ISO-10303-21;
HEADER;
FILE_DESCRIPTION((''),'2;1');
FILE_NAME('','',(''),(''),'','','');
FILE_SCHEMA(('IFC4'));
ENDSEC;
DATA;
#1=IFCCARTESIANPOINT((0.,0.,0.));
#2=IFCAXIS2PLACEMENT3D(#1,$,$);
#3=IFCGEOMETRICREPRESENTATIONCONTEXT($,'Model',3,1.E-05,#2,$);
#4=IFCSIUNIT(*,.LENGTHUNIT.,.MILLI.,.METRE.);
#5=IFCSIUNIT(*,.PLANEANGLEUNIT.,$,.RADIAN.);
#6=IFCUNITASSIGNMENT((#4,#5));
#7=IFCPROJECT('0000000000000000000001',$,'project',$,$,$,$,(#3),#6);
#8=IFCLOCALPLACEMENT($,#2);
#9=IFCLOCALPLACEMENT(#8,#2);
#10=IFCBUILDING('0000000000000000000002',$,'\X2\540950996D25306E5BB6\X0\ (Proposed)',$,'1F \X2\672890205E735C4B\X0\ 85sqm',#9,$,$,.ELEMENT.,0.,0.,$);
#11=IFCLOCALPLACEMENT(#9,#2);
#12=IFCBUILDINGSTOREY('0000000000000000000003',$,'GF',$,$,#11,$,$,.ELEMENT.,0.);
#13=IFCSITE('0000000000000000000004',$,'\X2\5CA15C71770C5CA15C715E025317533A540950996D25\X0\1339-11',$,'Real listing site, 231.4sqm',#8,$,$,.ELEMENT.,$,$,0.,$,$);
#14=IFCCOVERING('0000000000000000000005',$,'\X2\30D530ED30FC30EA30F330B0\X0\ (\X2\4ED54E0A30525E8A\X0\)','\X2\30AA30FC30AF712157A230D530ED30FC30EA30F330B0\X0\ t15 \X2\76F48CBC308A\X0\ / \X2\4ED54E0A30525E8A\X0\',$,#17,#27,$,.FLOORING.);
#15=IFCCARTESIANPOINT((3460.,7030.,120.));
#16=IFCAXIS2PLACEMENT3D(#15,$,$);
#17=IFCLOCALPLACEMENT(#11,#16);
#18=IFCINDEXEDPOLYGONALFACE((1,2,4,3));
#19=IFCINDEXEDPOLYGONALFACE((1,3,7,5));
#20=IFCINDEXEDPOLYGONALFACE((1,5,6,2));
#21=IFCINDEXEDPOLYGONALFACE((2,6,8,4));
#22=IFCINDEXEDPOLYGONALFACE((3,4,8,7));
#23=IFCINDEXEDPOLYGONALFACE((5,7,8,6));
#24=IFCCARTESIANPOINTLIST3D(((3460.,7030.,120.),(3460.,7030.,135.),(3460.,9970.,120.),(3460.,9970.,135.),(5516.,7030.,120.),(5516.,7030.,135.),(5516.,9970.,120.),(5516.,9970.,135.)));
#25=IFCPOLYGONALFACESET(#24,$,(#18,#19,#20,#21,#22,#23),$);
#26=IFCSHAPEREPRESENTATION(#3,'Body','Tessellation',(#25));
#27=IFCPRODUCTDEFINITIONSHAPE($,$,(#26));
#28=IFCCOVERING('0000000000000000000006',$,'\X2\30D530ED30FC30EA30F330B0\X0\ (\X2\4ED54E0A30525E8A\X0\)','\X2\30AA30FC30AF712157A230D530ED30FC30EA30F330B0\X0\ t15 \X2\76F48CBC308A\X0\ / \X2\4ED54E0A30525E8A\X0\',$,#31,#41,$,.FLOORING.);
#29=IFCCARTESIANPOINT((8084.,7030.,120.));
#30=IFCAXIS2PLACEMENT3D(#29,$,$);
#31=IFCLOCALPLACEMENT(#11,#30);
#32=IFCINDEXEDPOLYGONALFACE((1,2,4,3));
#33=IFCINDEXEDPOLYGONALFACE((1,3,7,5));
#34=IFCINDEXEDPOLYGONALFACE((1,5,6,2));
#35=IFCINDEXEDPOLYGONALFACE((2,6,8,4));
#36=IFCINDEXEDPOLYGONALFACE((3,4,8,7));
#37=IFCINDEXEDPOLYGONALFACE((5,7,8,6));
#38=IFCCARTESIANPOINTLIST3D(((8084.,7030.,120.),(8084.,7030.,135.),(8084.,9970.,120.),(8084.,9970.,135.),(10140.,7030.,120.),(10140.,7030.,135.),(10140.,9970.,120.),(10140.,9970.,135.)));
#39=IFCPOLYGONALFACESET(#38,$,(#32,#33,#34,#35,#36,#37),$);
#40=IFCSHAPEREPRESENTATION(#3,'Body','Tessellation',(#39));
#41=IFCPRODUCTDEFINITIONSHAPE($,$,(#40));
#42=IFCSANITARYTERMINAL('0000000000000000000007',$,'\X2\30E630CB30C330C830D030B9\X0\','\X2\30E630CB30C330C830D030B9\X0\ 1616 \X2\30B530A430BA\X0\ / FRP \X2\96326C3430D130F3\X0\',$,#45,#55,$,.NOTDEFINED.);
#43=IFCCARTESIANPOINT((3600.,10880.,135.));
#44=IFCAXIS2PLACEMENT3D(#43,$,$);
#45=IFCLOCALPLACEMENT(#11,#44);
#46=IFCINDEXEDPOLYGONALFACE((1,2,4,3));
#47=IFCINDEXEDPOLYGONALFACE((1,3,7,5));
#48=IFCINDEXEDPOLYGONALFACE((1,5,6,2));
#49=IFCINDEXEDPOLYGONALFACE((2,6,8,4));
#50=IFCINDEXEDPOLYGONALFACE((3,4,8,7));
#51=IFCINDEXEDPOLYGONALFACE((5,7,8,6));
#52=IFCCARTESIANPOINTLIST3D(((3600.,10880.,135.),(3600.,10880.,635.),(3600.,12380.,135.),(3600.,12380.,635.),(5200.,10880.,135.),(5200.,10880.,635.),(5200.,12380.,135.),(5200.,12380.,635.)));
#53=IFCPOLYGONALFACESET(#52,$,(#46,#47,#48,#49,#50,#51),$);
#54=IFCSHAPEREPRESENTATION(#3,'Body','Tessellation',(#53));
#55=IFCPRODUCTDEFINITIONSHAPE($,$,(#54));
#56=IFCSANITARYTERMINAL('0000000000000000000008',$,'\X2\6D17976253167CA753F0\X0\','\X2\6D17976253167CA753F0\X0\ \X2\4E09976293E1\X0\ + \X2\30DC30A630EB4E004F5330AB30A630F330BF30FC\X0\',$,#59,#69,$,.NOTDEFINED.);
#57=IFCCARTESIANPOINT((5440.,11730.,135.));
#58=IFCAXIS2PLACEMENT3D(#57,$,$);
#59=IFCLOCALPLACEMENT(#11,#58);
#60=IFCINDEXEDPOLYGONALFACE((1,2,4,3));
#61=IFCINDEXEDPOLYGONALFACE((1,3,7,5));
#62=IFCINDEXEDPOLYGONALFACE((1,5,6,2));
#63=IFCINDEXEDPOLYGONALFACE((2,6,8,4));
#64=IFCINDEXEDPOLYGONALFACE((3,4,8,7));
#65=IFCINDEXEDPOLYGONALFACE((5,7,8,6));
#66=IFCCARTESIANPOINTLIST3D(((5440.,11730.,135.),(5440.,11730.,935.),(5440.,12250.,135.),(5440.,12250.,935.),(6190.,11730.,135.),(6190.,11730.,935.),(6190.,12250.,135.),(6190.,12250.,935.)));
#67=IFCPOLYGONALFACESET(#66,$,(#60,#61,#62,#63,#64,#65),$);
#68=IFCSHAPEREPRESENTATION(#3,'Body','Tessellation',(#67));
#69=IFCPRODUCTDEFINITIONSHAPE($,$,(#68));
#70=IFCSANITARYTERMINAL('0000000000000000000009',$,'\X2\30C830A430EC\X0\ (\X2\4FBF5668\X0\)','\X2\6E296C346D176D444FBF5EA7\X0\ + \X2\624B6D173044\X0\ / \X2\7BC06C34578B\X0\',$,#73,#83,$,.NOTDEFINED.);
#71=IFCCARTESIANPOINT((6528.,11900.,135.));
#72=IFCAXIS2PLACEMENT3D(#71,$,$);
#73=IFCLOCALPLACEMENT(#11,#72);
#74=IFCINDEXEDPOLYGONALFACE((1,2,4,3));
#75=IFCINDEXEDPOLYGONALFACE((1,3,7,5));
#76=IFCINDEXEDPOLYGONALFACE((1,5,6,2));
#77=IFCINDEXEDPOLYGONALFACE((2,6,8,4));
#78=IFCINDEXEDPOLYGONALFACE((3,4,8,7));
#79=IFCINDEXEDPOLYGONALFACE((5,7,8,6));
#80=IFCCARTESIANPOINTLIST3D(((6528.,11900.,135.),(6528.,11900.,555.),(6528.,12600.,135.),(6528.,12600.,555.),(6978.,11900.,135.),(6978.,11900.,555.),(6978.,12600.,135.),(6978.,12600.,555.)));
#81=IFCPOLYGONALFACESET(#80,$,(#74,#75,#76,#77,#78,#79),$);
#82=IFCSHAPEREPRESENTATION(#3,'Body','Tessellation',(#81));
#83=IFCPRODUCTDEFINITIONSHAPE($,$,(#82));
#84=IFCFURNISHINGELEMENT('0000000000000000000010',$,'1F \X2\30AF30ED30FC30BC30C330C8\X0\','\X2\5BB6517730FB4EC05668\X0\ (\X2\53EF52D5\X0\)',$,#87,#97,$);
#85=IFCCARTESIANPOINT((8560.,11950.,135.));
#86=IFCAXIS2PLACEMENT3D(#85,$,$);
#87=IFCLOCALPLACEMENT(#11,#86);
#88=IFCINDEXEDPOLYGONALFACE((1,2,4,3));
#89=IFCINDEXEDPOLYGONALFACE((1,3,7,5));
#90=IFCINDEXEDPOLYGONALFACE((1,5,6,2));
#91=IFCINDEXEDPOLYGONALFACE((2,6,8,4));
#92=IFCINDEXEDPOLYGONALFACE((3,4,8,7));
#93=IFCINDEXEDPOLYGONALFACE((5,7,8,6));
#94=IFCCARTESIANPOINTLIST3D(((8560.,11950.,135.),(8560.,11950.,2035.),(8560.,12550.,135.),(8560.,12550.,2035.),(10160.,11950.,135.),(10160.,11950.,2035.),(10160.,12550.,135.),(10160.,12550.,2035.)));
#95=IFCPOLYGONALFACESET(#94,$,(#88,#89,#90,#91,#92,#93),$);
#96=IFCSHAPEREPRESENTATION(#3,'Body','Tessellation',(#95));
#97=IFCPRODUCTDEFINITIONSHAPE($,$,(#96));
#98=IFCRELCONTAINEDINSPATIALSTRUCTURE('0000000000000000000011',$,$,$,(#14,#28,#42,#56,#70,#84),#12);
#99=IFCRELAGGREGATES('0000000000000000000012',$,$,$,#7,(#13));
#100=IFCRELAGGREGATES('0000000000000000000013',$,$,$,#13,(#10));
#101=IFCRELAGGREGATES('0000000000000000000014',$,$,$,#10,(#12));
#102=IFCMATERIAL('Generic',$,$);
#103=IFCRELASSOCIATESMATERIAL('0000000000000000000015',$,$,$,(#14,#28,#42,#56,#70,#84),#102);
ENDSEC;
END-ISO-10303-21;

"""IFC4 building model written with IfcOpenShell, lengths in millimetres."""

from ifc_helpers import new_model, si_unit, frame, frame_2d, origin, place, context, project, spatial, rectangle, extrude, material, element, save


model = new_model("IFC4")

# Units and contexts
model_context = context("Model", 3, precision=1e-05, world=origin())
ifc_project = project(units=[si_unit("LENGTHUNIT", "METRE", prefix="MILLI"), si_unit("PLANEANGLEUNIT", "RADIAN")], contexts=[model_context])

# Site, building, storey
site_placement = place(None, origin())
site = spatial("IfcSite", under=ifc_project, at=site_placement, Name="岡山県岡山市北区吉備津1339-11", ObjectType="Real listing site, 231.4sqm", CompositionType="ELEMENT", RefElevation=0.0)
building_placement = place(site_placement, origin())
building = spatial("IfcBuilding", under=site, at=building_placement, Name="吉備津の家 (Proposed)", ObjectType="1F 木造平屋 85sqm", CompositionType="ELEMENT", ElevationOfRefHeight=0.0, ElevationOfTerrain=0.0)
storey_placement = place(building_placement, origin())
storey = spatial("IfcBuildingStorey", under=building, at=storey_placement, Name="GF", CompositionType="ELEMENT", Elevation=0.0)

# Coverings
ifc_material_1 = material(Name="Generic")
covering_1_placement = place(storey_placement, frame((3460.0, 7030.0, 120.0)))
element("IfcCovering", 1, at=covering_1_placement, inside=storey, material=ifc_material_1, Name="フローリング (仕上げ床)", Description="オーク無垢フローリング t15 直貼り / 仕上げ床", PredefinedType="FLOORING", context=model_context, shape_type="SweptSolid", body=[
    extrude(rectangle(XDim=2056.0, YDim=2940.0, at=frame_2d((1028.0, 1470.0))), frame((3460.0, 7030.0, 120.0)), (0.0, 0.0, 1.0), 15.0),
])
covering_2_placement = place(storey_placement, frame((8084.0, 7030.0, 120.0)))
element("IfcCovering", 2, at=covering_2_placement, inside=storey, material=ifc_material_1, Name="フローリング (仕上げ床)", Description="オーク無垢フローリング t15 直貼り / 仕上げ床", PredefinedType="FLOORING", context=model_context, shape_type="SweptSolid", body=[
    extrude(rectangle(XDim=2056.0, YDim=2940.0, at=frame_2d((1028.0, 1470.0))), frame((8084.0, 7030.0, 120.0)), (0.0, 0.0, 1.0), 15.0),
])

# Sanitary terminals
sanitary_terminal_1_placement = place(storey_placement, frame((3600.0, 10880.0, 135.0)))
element("IfcSanitaryTerminal", 3, at=sanitary_terminal_1_placement, inside=storey, material=ifc_material_1, Name="ユニットバス", Description="ユニットバス 1616 サイズ / FRP 防水パン", PredefinedType="NOTDEFINED", context=model_context, shape_type="SweptSolid", body=[
    extrude(rectangle(XDim=1600.0, YDim=1500.0, at=frame_2d((800.0, 750.0))), frame((3600.0, 10880.0, 135.0)), (0.0, 0.0, 1.0), 500.0),
])
sanitary_terminal_2_placement = place(storey_placement, frame((5440.0, 11730.0, 135.0)))
element("IfcSanitaryTerminal", 4, at=sanitary_terminal_2_placement, inside=storey, material=ifc_material_1, Name="洗面化粧台", Description="洗面化粧台 三面鏡 + ボウル一体カウンター", PredefinedType="NOTDEFINED", context=model_context, shape_type="SweptSolid", body=[
    extrude(rectangle(XDim=750.0, YDim=520.0, at=frame_2d((375.0, 260.0))), frame((5440.0, 11730.0, 135.0)), (0.0, 0.0, 1.0), 800.0),
])
sanitary_terminal_3_placement = place(storey_placement, frame((6528.0, 11900.0, 135.0)))
element("IfcSanitaryTerminal", 5, at=sanitary_terminal_3_placement, inside=storey, material=ifc_material_1, Name="トイレ (便器)", Description="温水洗浄便座 + 手洗い / 節水型", PredefinedType="NOTDEFINED", context=model_context, shape_type="SweptSolid", body=[
    extrude(rectangle(XDim=450.0, YDim=700.0, at=frame_2d((225.0, 350.0))), frame((6528.0, 11900.0, 135.0)), (0.0, 0.0, 1.0), 420.0),
])

# Furnishing element
furnishing_placement = place(storey_placement, frame((8560.0, 11950.0, 135.0)))
element("IfcFurnishingElement", 6, at=furnishing_placement, inside=storey, material=ifc_material_1, Name="1F クローゼット", Description="家具・什器 (可動)", context=model_context, shape_type="SweptSolid", body=[
    extrude(rectangle(XDim=1600.0, YDim=600.0, at=frame_2d((800.0, 300.0))), frame((8560.0, 11950.0, 135.0)), (0.0, 0.0, 1.0), 1900.0),
])

save(model, "model.ifc")
